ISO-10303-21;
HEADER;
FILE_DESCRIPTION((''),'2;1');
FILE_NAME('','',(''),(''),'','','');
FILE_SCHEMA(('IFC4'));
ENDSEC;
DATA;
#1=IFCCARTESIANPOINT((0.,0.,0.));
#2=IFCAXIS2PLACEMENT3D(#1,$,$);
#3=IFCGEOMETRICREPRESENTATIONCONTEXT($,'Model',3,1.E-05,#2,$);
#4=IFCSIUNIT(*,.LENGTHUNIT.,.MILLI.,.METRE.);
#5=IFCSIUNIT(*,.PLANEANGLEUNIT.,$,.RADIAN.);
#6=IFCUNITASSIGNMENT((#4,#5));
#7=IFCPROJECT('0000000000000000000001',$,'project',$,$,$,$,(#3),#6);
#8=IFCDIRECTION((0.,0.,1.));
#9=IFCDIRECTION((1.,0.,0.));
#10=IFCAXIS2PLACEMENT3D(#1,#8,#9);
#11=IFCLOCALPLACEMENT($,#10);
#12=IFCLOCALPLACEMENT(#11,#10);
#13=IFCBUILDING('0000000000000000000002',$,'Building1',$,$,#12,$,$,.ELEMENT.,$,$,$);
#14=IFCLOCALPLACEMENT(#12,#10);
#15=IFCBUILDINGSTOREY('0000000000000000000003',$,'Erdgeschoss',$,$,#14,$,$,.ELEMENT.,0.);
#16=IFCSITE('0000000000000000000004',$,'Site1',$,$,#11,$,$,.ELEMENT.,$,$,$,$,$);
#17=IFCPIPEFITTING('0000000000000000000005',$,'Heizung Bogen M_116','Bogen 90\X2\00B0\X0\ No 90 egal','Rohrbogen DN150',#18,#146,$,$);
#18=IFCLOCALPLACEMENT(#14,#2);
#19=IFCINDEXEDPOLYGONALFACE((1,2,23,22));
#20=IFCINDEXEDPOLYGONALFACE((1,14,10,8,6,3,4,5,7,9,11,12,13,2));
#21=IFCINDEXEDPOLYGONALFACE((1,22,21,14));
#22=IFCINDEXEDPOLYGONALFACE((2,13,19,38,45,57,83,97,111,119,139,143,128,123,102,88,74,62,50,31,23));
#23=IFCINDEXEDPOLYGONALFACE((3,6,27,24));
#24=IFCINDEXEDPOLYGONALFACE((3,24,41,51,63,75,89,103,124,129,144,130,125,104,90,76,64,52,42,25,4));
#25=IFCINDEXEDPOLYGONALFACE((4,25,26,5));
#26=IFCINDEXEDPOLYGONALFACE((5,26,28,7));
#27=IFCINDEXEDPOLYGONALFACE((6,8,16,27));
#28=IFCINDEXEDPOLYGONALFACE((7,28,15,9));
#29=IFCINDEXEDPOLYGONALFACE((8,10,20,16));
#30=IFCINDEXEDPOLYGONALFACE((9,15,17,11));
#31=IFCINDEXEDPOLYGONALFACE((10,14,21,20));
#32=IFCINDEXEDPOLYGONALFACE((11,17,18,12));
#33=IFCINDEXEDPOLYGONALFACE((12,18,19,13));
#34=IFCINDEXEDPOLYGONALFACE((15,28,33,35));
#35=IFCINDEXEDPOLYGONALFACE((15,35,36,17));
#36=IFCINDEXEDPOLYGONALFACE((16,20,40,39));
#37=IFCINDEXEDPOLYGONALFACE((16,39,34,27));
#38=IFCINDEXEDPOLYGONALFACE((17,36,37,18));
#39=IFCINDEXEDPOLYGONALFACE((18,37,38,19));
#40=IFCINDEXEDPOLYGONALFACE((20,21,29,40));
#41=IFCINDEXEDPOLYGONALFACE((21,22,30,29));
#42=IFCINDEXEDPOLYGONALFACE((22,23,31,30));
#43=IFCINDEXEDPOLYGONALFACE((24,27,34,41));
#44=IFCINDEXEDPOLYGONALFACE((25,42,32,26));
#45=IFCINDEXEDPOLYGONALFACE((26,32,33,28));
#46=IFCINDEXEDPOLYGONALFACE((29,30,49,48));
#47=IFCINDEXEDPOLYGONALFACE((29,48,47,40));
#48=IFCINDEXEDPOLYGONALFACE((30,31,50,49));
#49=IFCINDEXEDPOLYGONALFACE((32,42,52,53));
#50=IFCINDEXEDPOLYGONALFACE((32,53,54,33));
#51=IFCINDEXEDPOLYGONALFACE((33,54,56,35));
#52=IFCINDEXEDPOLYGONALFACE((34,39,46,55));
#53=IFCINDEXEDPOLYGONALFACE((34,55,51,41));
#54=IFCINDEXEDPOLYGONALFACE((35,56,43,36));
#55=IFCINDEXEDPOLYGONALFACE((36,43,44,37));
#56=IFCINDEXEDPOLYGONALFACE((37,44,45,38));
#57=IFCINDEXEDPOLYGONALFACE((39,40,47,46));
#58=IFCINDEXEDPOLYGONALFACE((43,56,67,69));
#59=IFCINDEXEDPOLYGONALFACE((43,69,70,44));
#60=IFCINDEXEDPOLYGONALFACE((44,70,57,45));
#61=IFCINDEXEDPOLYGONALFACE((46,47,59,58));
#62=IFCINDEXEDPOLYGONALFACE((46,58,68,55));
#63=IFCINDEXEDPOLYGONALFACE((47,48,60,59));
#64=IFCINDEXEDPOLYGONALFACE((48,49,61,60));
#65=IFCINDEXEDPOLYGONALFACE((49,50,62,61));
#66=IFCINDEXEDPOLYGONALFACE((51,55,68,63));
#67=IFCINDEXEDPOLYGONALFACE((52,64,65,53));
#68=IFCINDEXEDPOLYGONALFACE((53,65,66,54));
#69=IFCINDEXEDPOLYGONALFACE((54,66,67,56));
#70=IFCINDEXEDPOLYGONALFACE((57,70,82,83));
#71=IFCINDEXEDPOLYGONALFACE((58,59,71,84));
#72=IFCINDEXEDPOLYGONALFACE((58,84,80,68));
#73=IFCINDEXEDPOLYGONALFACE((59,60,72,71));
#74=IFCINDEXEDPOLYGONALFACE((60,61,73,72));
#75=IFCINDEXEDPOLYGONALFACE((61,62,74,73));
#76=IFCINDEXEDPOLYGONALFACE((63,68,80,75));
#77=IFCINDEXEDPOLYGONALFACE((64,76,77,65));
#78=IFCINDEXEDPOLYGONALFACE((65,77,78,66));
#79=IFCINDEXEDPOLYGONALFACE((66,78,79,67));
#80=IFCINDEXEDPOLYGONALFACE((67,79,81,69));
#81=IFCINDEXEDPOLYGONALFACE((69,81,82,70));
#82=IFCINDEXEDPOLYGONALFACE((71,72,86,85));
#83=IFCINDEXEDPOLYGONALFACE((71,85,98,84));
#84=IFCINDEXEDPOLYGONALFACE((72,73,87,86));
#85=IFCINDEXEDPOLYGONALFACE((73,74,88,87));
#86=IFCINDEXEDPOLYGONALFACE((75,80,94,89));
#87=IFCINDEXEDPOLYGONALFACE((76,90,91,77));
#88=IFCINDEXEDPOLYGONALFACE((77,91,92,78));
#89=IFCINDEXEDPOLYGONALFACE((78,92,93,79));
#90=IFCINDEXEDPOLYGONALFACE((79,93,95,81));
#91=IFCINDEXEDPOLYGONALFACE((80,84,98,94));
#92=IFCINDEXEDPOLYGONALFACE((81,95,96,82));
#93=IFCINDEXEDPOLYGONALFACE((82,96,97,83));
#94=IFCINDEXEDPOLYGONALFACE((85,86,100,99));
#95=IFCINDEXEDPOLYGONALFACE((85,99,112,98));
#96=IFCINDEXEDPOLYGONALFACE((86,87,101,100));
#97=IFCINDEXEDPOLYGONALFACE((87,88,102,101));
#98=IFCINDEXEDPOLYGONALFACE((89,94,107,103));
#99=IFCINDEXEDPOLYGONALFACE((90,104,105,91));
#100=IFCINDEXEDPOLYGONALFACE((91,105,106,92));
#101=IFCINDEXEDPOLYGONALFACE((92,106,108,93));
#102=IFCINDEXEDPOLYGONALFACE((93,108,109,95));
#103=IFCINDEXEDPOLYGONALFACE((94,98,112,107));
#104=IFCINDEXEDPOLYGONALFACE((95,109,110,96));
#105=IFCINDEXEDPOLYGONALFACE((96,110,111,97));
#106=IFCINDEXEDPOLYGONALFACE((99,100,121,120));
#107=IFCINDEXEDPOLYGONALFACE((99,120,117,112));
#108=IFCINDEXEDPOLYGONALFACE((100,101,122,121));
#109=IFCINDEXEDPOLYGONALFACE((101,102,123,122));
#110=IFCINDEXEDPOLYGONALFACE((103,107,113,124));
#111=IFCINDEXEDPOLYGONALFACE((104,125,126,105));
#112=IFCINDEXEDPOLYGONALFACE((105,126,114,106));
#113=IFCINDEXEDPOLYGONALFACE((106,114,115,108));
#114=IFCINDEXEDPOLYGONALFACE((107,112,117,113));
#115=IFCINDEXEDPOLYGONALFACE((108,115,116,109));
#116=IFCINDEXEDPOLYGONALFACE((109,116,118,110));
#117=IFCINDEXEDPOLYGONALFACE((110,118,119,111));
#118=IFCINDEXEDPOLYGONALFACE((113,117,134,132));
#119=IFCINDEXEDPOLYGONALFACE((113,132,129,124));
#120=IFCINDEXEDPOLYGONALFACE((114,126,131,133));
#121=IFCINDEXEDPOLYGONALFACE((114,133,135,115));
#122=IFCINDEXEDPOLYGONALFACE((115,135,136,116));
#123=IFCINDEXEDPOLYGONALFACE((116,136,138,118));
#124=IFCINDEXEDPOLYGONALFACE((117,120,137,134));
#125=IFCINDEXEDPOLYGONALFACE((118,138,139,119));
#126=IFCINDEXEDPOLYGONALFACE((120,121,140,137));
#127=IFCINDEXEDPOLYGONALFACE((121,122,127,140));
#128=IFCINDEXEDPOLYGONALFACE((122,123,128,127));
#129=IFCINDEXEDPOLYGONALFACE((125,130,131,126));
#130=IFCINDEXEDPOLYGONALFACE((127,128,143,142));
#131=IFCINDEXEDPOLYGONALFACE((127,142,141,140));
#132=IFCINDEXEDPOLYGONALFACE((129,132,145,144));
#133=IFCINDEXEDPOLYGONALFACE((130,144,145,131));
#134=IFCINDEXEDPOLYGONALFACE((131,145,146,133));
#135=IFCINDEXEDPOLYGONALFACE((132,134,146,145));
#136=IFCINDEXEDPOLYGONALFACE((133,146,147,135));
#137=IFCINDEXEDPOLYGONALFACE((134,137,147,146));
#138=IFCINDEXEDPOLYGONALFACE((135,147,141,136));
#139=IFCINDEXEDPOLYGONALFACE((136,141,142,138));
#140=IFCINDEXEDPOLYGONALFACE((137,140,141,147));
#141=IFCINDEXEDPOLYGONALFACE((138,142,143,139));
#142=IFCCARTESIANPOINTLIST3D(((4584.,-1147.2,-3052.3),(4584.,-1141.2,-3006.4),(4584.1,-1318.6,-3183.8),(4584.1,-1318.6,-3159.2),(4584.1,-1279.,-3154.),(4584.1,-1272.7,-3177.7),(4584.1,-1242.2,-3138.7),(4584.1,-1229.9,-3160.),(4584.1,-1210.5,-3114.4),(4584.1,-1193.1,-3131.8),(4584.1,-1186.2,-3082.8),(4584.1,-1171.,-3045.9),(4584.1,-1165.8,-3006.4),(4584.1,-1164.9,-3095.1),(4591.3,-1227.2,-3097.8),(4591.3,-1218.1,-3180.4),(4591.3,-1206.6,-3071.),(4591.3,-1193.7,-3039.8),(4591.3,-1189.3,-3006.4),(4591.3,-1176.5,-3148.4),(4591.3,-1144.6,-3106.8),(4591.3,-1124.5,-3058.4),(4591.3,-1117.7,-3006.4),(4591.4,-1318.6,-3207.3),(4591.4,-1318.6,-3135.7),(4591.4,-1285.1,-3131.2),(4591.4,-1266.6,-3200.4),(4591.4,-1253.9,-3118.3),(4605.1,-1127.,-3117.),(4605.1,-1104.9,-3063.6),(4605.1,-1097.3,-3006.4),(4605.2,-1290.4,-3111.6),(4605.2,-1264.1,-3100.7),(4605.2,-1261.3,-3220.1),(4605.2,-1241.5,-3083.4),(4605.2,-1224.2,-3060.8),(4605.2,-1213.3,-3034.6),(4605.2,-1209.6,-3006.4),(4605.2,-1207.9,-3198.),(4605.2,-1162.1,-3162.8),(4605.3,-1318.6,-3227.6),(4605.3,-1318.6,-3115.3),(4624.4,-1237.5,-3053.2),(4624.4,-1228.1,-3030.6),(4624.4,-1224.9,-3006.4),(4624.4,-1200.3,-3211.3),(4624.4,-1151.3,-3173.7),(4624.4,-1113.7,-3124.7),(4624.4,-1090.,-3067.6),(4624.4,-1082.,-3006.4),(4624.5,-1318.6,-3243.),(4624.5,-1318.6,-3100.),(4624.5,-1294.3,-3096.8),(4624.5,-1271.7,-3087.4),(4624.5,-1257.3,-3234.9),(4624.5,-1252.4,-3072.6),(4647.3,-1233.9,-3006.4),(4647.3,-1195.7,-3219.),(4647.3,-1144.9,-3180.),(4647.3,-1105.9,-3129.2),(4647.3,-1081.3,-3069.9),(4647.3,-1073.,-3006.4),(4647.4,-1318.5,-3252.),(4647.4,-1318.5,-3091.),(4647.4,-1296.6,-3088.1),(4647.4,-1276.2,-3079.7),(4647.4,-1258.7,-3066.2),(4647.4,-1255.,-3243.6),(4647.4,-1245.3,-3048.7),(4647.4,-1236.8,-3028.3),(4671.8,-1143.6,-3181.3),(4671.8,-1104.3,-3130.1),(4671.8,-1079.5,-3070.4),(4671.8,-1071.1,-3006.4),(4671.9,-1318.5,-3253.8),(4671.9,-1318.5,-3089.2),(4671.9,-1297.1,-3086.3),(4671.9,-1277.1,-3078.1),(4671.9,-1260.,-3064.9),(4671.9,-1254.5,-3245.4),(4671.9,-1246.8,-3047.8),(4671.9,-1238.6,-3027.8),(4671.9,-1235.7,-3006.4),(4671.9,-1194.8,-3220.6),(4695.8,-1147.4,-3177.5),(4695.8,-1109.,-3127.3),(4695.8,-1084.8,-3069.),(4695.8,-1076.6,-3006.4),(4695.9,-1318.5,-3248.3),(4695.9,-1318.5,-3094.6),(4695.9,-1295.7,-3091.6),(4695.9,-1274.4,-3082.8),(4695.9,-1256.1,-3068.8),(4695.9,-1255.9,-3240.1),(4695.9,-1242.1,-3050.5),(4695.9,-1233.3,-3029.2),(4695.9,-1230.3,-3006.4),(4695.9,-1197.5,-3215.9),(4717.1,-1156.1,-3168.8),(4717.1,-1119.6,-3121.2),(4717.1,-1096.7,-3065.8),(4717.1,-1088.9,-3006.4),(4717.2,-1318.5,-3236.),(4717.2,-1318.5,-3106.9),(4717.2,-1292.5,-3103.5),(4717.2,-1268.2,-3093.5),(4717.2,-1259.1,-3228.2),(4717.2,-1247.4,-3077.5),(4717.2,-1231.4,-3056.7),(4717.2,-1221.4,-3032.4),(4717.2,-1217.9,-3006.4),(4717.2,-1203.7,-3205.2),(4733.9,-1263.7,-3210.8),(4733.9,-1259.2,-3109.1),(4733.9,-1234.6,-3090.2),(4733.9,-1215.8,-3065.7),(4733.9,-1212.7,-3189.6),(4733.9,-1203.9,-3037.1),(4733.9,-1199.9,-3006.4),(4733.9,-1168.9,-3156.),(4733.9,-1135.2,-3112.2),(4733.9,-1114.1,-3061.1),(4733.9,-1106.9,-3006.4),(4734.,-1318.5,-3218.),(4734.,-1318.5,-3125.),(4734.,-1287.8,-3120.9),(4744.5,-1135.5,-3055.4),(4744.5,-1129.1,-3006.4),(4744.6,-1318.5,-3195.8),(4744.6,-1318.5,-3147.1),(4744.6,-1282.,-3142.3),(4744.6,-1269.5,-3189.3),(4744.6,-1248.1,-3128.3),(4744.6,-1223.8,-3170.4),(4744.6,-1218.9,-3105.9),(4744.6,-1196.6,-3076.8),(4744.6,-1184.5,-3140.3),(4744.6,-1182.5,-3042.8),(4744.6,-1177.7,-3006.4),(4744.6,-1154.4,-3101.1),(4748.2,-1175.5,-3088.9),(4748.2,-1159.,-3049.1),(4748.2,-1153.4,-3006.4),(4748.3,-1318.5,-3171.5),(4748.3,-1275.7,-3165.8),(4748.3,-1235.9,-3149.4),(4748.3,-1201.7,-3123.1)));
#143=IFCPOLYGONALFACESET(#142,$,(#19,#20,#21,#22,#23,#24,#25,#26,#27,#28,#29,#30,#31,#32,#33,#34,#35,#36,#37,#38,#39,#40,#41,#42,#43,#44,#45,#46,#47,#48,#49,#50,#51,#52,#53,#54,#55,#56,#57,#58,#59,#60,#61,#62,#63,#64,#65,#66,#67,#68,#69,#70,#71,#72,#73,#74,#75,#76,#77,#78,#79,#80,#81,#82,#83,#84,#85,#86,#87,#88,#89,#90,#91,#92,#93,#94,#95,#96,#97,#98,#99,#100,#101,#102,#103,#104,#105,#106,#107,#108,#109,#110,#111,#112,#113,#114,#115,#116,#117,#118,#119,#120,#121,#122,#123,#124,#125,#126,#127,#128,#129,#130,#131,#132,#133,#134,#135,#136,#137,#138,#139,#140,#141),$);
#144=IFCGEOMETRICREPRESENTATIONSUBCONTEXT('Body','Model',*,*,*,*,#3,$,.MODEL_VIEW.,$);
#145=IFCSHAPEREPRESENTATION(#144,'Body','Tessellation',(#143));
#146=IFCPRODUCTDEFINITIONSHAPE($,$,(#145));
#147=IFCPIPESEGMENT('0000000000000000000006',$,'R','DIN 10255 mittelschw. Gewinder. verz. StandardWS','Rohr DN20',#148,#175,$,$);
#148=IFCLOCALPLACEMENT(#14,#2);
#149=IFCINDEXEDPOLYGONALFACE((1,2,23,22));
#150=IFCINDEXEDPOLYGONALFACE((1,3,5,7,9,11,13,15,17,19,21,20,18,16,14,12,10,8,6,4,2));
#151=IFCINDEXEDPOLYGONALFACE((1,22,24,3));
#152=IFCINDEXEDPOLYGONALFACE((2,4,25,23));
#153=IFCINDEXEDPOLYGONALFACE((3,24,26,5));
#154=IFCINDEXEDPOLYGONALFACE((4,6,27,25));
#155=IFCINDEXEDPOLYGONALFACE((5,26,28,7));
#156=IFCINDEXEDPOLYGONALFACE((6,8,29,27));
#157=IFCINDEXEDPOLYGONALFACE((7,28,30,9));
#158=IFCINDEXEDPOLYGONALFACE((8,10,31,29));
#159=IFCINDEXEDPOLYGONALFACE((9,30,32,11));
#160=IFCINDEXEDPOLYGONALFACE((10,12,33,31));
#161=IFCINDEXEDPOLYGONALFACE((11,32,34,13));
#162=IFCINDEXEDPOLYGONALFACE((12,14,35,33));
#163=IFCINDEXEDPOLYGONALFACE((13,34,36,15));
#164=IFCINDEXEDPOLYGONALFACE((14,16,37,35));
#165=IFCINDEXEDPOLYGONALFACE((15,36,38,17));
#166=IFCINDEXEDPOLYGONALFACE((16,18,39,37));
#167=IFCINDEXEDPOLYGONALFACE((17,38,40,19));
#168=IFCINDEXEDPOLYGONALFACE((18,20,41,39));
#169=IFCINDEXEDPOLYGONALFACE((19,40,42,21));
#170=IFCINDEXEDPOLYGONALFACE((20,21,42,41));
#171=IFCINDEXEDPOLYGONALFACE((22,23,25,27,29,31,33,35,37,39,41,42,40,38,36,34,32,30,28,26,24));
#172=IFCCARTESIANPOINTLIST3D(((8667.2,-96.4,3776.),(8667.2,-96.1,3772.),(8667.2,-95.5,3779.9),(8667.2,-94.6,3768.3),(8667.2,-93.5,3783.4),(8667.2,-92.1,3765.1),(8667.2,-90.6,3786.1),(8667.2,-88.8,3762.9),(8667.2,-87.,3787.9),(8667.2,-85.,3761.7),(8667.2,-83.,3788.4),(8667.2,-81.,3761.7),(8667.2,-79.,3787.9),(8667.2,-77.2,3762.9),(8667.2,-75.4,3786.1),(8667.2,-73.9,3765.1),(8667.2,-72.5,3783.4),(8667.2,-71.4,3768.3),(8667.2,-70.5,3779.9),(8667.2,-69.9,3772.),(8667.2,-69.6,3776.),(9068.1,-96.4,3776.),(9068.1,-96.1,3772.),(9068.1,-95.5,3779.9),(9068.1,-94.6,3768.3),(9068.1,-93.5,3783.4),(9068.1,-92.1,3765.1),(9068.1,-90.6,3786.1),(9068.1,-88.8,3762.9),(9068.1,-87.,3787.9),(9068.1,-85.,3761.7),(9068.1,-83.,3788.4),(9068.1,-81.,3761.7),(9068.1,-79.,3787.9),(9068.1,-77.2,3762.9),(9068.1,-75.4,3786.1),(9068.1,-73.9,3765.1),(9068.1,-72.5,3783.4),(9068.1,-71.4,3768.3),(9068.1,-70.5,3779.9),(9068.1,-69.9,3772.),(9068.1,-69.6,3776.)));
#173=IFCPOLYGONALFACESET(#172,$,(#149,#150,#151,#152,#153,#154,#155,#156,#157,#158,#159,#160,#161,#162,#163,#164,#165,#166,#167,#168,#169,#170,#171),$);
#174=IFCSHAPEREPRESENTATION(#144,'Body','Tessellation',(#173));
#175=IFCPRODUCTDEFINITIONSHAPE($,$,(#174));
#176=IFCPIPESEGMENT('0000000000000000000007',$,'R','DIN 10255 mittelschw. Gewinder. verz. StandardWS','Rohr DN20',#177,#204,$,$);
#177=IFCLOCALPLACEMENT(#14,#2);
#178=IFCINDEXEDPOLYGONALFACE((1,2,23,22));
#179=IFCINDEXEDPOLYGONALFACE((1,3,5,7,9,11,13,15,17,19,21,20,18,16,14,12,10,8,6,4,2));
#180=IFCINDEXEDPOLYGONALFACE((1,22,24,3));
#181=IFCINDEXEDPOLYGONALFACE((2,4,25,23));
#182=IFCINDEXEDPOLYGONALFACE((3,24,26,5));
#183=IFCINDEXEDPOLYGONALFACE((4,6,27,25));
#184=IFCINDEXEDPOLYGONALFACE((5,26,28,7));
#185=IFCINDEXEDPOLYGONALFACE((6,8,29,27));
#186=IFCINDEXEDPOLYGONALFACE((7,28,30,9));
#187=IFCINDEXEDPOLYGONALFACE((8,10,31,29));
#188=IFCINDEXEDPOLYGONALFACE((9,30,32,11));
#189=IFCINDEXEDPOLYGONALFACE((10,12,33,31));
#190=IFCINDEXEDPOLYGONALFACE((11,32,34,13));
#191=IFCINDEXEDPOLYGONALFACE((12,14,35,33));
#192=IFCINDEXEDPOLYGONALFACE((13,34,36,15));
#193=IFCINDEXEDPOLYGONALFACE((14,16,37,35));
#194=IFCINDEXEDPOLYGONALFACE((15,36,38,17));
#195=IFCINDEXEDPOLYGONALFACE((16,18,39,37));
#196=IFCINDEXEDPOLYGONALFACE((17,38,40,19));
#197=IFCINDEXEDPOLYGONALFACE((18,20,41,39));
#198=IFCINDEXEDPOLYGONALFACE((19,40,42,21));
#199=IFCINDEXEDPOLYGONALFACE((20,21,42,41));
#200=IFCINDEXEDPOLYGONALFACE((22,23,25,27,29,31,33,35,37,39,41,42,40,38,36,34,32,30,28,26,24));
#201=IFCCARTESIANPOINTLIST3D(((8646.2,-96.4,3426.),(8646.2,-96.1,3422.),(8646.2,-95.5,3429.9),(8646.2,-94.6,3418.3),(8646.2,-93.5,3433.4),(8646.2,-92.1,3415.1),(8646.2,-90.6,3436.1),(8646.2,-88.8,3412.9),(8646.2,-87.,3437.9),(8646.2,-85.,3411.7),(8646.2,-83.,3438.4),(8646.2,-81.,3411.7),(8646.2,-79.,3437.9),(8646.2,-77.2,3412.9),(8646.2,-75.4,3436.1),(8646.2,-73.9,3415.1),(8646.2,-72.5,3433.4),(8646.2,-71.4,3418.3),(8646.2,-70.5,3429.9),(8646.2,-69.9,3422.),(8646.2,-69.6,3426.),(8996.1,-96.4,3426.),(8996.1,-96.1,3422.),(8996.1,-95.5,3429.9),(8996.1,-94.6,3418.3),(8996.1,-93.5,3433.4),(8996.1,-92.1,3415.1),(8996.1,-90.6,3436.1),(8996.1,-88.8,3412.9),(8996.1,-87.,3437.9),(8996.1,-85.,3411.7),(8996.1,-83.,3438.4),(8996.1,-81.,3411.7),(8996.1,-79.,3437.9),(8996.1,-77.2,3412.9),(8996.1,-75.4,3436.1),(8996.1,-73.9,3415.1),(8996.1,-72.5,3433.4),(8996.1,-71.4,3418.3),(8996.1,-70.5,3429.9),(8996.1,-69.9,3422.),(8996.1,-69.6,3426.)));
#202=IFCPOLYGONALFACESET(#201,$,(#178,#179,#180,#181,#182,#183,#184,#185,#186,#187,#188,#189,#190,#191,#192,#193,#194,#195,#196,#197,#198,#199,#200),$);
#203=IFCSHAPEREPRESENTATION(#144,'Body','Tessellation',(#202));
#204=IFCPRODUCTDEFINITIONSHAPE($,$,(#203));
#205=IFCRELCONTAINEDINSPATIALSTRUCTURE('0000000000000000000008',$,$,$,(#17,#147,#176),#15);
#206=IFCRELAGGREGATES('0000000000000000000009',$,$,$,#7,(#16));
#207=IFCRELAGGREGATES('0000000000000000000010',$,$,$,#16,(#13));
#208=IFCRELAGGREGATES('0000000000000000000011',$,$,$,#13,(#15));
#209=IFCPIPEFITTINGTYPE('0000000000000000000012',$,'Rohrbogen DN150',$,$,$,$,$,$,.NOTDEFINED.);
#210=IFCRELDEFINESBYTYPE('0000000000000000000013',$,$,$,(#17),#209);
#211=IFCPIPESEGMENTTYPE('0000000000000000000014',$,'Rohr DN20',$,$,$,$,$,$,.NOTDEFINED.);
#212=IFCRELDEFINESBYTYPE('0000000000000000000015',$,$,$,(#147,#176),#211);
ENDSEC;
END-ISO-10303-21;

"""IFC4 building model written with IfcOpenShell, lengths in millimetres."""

from ifc_helpers import new_model, entity, si_unit, frame, origin, origin_with_axes, origin_2d_with_axis, place, context, subcontext, project, spatial, circle, extrude, source, transform, mapped, type_object, element, save


model = new_model("IFC4")

# Units and contexts
model_context = context("Model", 3, precision=1e-05, world=origin())
body_context = subcontext(model_context, "Body", "Model", "MODEL_VIEW")
ifc_project = project(units=[si_unit("LENGTHUNIT", "METRE", prefix="MILLI"), si_unit("PLANEANGLEUNIT", "RADIAN")], contexts=[model_context])

# Site, building, storey
site_placement = place(None, origin_with_axes())
site = spatial("IfcSite", under=ifc_project, at=site_placement, Name="Site1", CompositionType="ELEMENT")
building_placement = place(site_placement, origin_with_axes())
building = spatial("IfcBuilding", under=site, at=building_placement, Name="Building1", CompositionType="ELEMENT")
storey_placement = place(building_placement, origin_with_axes())
storey = spatial("IfcBuildingStorey", under=building, at=storey_placement, Name="Erdgeschoss", CompositionType="ELEMENT", Elevation=0.0)

# Pipe fitting
pipe_fitting_type_1 = type_object("IfcPipeFittingType", Name="Rohrbogen DN150", PredefinedType="NOTDEFINED")
shared_shape_1 = source(origin_with_axes(), body_context, "Body", "SolidModel", [
    entity("IfcRevolvedAreaSolid", entity("IfcCircleProfileDef", "AREA", None, entity("IfcAxis2Placement2D", entity("IfcCartesianPoint", [0.0, 0.0]), entity("IfcDirection", [1.0, 0.0])), 82.5), entity("IfcAxis2Placement3D", entity("IfcCartesianPoint", [123.8, 0.0, 41.3]), entity("IfcDirection", [-1.0, 0.0, 0.0]), entity("IfcDirection", [0.0, 1.0, 0.000562])), entity("IfcAxis1Placement", entity("IfcCartesianPoint", [0.0, 165.1, 0.0]), entity("IfcDirection", [-1.0, 0.0, 0.0])), 1.570796),
])
pipe_fitting_1_placement = place(storey_placement, frame((4665.7, -1194.7, -3130.2), z_axis=(0.0, 0.0, 1.0), x_axis=(1.0, 0.0, 0.0)))
element("IfcPipeFitting", 1, at=pipe_fitting_1_placement, inside=storey, type_object=pipe_fitting_type_1, Name="Heizung Bogen M_116", Description="Bogen 90° No 90 egal", ObjectType="Rohrbogen DN150", context=body_context, shape_type="MappedRepresentation", body=[
    mapped(shared_shape_1, transform((0.0, 0.0, 0.0), x_axis=(0.0, 0.0, 1.0), y_axis=(1.0, 0.0, 0.0), z_axis=(0.0, 1.0, 0.0), scale=1.0)),
])

# Pipe segments
pipe_segment_type_1 = type_object("IfcPipeSegmentType", Name="Rohr DN20", PredefinedType="NOTDEFINED")
pipe_segment_1_placement = place(storey_placement, frame((8867.7, -83.2, 3775.0), z_axis=(0.0, 0.0, 1.0), x_axis=(1.0, 0.0, 0.0)))
element("IfcPipeSegment", 2, at=pipe_segment_1_placement, inside=storey, type_object=pipe_segment_type_1, Name="R", Description="DIN 10255 mittelschw. Gewinder. verz. StandardWS", ObjectType="Rohr DN20", context=body_context, shape_type="SolidModel", body=[
    extrude(circle(Radius=13.4, at=origin_2d_with_axis()), frame((200.5, 0.1, 0.0), z_axis=(-1.0, 0.0, 0.0), x_axis=(0.0, 0.0, 1.0)), (0.0, 0.0, 1.0), 400.9),
])
pipe_segment_2_placement = place(storey_placement, frame((8821.2, -83.2, 3425.0), z_axis=(0.0, 0.0, 1.0), x_axis=(1.0, 0.0, 0.0)))
element("IfcPipeSegment", 3, at=pipe_segment_2_placement, inside=storey, type_object=pipe_segment_type_1, Name="R", Description="DIN 10255 mittelschw. Gewinder. verz. StandardWS", ObjectType="Rohr DN20", context=body_context, shape_type="SolidModel", body=[
    extrude(circle(Radius=13.4, at=origin_2d_with_axis()), frame((175.0, 0.2, 0.0), z_axis=(-1.0, 0.0, 0.0), x_axis=(0.0, 0.0, 1.0)), (0.0, 0.0, 1.0), 349.9),
])

save(model, "model.ifc")
